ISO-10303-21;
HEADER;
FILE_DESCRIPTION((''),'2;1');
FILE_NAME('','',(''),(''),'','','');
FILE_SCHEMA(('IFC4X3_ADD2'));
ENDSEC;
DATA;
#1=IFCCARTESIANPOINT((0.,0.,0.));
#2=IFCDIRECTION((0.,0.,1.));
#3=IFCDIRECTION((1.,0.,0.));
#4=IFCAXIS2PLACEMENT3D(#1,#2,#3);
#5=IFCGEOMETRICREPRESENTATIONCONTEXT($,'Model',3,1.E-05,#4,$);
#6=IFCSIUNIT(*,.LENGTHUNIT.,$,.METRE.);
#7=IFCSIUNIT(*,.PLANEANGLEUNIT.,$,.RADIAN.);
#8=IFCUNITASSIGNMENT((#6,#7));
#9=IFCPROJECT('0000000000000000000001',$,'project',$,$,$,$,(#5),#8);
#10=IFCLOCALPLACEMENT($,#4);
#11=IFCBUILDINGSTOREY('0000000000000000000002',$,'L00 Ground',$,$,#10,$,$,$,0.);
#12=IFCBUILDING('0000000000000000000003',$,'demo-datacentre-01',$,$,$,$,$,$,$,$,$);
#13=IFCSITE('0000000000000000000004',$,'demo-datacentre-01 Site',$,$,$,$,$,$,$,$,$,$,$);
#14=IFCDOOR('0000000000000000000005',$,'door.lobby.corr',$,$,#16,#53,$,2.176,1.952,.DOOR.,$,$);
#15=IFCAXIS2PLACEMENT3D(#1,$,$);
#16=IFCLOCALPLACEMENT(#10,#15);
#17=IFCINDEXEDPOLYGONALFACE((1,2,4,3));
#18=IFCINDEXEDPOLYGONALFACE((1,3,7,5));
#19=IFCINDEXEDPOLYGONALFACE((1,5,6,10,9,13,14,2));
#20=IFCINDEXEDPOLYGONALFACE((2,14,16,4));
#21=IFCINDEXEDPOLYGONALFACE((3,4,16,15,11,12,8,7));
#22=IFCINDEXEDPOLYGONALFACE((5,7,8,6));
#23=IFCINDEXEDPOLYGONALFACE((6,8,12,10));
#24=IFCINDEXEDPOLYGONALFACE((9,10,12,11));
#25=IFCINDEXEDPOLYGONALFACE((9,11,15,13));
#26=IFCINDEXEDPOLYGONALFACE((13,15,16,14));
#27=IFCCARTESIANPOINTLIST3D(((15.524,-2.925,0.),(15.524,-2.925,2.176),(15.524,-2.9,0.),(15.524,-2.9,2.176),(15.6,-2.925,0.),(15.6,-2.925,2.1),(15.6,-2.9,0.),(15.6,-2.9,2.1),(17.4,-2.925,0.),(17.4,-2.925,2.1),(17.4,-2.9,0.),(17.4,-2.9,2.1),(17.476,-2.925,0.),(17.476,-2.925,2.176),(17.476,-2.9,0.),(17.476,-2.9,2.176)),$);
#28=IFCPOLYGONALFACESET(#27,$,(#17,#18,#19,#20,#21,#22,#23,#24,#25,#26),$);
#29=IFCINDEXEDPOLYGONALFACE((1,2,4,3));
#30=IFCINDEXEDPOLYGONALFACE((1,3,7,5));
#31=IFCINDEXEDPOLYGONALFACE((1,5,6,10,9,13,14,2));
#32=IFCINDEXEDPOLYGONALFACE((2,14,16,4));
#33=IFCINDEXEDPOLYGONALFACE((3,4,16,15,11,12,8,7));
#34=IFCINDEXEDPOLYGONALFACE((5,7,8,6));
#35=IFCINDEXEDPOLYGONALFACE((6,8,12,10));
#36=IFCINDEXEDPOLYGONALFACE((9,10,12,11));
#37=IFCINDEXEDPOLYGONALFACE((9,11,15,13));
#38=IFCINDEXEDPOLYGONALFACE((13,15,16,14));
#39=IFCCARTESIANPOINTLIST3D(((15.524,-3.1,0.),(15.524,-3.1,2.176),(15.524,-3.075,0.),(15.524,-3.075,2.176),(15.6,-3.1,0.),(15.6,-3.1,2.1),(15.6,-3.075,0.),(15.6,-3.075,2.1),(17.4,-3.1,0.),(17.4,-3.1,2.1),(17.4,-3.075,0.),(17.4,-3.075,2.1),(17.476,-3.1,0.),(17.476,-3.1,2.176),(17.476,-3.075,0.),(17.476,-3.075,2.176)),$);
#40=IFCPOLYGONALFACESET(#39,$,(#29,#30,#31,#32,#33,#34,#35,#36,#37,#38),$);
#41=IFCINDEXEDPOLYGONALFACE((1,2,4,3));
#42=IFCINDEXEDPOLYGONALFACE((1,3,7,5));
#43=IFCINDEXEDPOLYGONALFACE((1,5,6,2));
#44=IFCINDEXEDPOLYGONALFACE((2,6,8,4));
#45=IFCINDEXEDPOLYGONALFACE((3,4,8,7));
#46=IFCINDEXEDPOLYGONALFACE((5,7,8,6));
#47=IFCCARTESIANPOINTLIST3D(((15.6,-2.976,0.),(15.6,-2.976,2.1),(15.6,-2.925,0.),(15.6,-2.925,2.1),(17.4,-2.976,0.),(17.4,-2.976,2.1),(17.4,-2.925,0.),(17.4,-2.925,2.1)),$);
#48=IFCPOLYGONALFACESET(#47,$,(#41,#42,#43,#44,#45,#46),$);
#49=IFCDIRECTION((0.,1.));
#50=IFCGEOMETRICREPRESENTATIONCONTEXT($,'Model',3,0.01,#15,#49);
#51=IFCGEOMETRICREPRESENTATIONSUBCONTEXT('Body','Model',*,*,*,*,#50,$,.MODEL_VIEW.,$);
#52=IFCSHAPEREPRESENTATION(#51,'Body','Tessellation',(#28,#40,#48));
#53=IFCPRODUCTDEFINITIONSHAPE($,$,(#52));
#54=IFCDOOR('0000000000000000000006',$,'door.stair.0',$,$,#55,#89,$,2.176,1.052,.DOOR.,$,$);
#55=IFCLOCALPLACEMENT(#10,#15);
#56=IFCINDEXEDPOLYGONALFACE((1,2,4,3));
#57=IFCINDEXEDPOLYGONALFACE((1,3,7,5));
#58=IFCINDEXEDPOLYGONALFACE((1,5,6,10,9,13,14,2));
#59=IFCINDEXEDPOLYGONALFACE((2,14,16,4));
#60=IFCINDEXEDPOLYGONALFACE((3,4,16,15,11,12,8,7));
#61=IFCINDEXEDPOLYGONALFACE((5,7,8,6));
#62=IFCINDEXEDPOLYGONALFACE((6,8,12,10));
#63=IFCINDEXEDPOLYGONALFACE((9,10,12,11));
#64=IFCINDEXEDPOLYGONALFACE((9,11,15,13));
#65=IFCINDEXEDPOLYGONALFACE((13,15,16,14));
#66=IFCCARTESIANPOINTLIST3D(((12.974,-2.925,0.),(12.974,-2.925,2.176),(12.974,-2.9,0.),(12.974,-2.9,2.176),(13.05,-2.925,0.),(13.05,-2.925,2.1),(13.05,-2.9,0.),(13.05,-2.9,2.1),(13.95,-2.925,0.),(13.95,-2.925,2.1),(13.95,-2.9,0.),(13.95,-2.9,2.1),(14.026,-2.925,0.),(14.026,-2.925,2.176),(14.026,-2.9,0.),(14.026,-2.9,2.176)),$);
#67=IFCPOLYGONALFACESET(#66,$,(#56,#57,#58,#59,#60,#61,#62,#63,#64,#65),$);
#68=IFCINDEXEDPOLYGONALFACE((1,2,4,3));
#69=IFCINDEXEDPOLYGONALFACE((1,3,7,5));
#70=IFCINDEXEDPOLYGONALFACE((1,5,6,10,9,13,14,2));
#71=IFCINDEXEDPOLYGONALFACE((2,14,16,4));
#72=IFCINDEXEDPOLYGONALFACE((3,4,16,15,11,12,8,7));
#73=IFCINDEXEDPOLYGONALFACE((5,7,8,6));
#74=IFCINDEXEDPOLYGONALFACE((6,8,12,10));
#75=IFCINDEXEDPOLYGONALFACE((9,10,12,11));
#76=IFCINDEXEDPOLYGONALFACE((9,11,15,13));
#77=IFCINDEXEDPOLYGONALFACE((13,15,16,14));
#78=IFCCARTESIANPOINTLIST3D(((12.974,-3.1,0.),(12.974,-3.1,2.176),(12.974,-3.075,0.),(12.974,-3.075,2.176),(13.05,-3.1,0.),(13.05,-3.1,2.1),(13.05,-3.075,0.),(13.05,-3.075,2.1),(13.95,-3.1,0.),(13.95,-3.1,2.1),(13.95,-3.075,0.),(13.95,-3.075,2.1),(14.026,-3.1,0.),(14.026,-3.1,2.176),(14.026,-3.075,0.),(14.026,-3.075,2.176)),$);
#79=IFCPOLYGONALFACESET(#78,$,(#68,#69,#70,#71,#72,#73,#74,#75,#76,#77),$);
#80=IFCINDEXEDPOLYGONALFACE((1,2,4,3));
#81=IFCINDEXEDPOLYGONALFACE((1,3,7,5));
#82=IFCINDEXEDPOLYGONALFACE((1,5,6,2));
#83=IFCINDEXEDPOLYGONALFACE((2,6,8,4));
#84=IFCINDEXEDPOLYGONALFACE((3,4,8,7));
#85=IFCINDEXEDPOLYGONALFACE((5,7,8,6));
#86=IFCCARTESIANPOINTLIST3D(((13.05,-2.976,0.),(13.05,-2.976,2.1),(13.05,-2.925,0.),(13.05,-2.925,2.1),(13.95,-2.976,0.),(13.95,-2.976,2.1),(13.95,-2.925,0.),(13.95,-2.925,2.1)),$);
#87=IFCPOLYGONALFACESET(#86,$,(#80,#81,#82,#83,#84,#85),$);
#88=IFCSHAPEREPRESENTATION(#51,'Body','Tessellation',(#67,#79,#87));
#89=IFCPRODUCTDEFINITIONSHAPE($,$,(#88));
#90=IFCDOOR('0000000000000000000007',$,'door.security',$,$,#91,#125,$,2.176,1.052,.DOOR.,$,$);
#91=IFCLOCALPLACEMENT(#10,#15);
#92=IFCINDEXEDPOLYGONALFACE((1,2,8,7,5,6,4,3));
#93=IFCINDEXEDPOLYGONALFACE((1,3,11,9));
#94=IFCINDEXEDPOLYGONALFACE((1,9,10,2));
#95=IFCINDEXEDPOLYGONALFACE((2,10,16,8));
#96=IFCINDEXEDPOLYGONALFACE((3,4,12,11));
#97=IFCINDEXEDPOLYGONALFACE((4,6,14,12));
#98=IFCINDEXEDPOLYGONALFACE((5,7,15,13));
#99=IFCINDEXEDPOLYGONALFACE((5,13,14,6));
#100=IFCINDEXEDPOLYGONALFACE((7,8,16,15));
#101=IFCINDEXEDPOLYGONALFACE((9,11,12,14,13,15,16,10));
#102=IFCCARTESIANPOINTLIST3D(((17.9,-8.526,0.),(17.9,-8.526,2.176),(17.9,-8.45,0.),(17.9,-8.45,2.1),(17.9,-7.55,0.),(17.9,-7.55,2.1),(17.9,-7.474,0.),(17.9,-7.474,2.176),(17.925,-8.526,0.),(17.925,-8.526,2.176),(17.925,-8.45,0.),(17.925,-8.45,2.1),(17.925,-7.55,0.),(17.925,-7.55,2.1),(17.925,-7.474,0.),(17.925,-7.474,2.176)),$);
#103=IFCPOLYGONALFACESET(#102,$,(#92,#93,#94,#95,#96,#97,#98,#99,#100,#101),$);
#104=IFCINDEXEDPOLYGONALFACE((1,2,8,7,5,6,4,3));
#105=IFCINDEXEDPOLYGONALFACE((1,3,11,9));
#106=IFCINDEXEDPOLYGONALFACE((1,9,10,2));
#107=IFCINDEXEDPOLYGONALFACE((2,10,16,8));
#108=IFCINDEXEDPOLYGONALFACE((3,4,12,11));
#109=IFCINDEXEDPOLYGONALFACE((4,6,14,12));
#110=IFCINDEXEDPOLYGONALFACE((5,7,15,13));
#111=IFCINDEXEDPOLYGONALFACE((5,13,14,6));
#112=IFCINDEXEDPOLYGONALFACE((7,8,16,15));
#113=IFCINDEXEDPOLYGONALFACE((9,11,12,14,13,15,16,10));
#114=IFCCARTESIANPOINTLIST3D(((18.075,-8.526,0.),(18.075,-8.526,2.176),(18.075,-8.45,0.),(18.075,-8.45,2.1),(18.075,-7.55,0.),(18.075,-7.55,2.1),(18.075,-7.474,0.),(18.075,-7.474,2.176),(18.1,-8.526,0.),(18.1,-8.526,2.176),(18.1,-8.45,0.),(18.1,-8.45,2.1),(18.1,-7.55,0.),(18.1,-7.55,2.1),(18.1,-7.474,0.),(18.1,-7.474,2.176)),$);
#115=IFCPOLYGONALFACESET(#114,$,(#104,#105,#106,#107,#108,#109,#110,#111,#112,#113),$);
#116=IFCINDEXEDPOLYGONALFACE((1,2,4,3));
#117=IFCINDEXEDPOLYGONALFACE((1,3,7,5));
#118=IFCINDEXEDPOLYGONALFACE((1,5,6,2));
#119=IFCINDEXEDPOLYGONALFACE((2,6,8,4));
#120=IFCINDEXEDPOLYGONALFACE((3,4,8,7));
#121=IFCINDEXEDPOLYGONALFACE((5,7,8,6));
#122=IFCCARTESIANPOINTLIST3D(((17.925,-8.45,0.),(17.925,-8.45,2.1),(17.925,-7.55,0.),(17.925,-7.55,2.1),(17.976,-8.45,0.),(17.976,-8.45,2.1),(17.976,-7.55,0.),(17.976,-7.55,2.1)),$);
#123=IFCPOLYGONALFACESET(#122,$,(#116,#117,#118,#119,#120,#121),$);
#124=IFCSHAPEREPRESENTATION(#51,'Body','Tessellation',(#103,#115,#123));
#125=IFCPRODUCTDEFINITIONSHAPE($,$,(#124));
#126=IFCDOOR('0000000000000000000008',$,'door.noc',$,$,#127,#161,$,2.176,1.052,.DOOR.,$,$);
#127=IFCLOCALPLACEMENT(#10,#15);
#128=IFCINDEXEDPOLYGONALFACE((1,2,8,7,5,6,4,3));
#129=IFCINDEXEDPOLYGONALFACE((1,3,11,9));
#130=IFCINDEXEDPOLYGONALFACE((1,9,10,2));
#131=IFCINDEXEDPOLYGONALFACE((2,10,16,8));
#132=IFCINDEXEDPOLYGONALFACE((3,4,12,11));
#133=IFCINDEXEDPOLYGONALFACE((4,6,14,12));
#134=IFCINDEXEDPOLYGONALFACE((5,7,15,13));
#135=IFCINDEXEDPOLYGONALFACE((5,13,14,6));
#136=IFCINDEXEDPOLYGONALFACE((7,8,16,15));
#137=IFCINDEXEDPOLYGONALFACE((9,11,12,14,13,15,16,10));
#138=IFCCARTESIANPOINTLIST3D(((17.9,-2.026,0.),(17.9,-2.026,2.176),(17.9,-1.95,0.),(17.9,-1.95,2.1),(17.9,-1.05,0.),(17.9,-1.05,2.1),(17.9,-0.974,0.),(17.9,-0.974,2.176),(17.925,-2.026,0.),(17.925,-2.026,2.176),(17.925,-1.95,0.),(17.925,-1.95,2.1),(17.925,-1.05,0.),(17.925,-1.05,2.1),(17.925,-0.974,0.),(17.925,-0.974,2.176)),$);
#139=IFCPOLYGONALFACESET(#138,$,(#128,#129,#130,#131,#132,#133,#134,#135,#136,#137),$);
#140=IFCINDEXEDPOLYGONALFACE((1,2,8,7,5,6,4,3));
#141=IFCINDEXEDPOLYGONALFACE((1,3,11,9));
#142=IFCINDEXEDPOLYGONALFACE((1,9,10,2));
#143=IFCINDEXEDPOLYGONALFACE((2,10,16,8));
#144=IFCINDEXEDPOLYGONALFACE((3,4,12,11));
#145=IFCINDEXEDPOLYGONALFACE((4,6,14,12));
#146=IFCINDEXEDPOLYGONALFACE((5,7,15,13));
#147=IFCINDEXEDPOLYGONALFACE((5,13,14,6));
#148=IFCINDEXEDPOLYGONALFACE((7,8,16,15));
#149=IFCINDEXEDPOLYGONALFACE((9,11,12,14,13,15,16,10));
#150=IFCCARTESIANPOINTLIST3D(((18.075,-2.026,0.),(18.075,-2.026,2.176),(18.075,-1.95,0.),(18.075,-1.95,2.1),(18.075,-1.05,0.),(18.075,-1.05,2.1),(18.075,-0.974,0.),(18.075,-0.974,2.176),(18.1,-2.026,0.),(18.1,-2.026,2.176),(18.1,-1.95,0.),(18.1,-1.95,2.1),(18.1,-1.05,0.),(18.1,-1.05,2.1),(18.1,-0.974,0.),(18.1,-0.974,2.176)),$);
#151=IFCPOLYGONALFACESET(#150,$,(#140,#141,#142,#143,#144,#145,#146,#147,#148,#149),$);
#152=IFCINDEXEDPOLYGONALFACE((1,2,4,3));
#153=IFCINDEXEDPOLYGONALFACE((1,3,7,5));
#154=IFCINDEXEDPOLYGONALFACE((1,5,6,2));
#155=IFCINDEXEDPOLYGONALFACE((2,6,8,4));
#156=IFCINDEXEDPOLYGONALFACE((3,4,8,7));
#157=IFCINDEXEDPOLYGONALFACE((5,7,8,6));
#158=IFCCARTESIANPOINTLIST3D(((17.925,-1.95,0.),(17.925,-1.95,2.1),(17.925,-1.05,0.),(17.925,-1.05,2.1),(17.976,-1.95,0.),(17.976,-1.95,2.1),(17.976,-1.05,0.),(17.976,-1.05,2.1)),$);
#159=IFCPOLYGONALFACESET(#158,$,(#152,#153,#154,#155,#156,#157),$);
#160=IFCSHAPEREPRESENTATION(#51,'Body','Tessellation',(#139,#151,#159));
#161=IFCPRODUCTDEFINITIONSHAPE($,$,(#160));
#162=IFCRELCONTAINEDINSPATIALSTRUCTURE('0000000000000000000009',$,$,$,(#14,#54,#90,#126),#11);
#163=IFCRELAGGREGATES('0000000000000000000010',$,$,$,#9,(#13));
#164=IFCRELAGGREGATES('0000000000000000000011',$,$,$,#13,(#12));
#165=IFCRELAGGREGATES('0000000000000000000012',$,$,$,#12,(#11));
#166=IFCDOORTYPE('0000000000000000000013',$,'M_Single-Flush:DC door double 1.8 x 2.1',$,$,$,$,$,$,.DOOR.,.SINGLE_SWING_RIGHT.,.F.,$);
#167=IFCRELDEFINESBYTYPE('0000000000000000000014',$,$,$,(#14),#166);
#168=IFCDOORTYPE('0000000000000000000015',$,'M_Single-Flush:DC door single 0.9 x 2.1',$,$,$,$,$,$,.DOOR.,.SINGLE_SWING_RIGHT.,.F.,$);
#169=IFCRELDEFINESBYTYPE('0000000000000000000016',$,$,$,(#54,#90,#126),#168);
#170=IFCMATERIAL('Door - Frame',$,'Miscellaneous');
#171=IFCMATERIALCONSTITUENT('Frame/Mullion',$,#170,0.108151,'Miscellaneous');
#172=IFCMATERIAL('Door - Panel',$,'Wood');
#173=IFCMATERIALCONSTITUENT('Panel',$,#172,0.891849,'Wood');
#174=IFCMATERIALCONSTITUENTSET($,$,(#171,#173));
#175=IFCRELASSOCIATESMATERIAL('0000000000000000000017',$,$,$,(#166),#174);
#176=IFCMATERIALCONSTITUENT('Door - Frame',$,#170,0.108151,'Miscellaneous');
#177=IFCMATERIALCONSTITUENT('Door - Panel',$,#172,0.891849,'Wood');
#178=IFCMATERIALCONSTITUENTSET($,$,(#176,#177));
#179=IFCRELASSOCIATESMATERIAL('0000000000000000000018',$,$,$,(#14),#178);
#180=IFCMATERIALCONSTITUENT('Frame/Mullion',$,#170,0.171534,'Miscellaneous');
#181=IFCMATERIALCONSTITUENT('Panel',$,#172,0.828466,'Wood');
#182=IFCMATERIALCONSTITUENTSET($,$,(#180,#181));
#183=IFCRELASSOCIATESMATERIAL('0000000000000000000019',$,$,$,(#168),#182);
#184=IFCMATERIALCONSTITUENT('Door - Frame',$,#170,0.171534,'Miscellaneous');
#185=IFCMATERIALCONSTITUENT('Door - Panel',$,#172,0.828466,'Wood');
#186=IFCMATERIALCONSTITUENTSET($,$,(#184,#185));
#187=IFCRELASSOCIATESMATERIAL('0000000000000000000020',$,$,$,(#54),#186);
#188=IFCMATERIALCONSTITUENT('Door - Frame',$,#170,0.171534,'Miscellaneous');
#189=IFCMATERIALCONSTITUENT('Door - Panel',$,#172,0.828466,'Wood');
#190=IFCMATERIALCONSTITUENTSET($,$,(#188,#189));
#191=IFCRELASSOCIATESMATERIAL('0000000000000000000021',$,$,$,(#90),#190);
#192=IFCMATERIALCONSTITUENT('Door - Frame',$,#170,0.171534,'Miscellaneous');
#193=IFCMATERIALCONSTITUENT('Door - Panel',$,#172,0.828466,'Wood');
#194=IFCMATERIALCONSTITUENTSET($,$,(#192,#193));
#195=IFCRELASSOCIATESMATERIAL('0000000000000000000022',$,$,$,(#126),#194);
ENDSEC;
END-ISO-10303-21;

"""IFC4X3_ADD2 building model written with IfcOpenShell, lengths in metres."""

from ifc_helpers import new_model, si_unit, direction, frame, frame_2d, origin, origin_with_axes, place, context, subcontext, project, spatial, polyline, rectangle, outline, extrude, source, transform, mapped, material, constituent, constituent_set, type_object, type_shapes, element, save


model = new_model("IFC4X3_ADD2")

# Units and contexts
model_context_1 = context("Model", 3, precision=0.01, world=origin(), true_north=direction((0.0, 1.0)))
model_context_2 = context("Model", 3, precision=1e-05, world=origin_with_axes())
body_context = subcontext(model_context_1, "Body", "Model", "MODEL_VIEW")
ifc_project = project(units=[si_unit("LENGTHUNIT", "METRE"), si_unit("PLANEANGLEUNIT", "RADIAN")], contexts=[model_context_2])

# Site, building, storey
site = spatial("IfcSite", under=ifc_project, Name="demo-datacentre-01 Site")
building = spatial("IfcBuilding", under=site, Name="demo-datacentre-01")
storey_placement = place(None, origin_with_axes())
storey = spatial("IfcBuildingStorey", under=building, at=storey_placement, Name="L00 Ground", Elevation=0.0)

# Shared definitions
placement_1 = place(None, origin())
placement_2 = place(placement_1, origin())
placement_3 = place(placement_2, origin())

# Doors
ifc_material_1 = material(Name="Door - Frame", Category="Miscellaneous")
ifc_material_2 = material(Name="Door - Panel", Category="Wood")
ifc_constituent_1 = constituent(ifc_material_1, Name="Door - Frame", Category="Miscellaneous", fraction=0.108151)
ifc_constituent_2 = constituent(ifc_material_2, Name="Door - Panel", Category="Wood", fraction=0.891849)
ifc_constituent_set_1 = constituent_set(constituents=[ifc_constituent_1, ifc_constituent_2])
ifc_constituent_3 = constituent(ifc_material_1, Name="Frame/Mullion", Category="Miscellaneous", fraction=0.108151)
ifc_constituent_4 = constituent(ifc_material_2, Name="Panel", Category="Wood", fraction=0.891849)
ifc_constituent_set_2 = constituent_set(constituents=[ifc_constituent_3, ifc_constituent_4])
door_type_1 = type_object("IfcDoorType", Name="M_Single-Flush:DC door double 1.8 x 2.1", OperationType="SINGLE_SWING_RIGHT", ParameterTakesPrecedence=False, PredefinedType="DOOR", material=ifc_constituent_set_2)
shared_shape_1 = source(origin(), body_context, "Body", "SweptSolid", [
    extrude(outline(polyline([(-0.976, -1.107), (0.976, -1.107), (0.976, 1.069), (0.9, 1.069), (0.9, -1.031), (-0.9, -1.031), (-0.9, 1.069), (-0.976, 1.069), (-0.976, -1.107)])), frame((0.9, 0.15, 1.069), z_axis=(0.0, 1.0, 0.0), x_axis=(1.0, 0.0, 0.0)), (0.0, 0.0, 1.0), 0.025),
    extrude(outline(polyline([(-1.107, -0.976), (1.069, -0.976), (1.069, -0.9), (-1.031, -0.9), (-1.031, 0.9), (1.069, 0.9), (1.069, 0.976), (-1.107, 0.976), (-1.107, -0.976)])), frame((0.9, -0.025, 1.069), z_axis=(0.0, 1.0, 0.0), x_axis=(0.0, 0.0, -1.0)), (0.0, 0.0, 1.0), 0.025),
    extrude(rectangle(XDim=0.051, YDim=1.8, at=frame_2d((0.0, 0.0), x_axis=(1.0, 0.0))), frame((0.9, 0.1245, 0.0), z_axis=(0.0, 0.0, 1.0), x_axis=(0.0, 1.0, 0.0)), (0.0, 0.0, 1.0), 2.1),
])
type_shapes(door_type_1, [shared_shape_1])
door_1_placement = place(placement_3, frame((15.6, -3.075, 0.0)))
element("IfcDoor", 1, at=door_1_placement, inside=storey, type_object=door_type_1, material=ifc_constituent_set_1, Name="door.lobby.corr", OverallHeight=2.176, OverallWidth=1.952, PredefinedType="DOOR", context=body_context, shape_type="MappedRepresentation", body=[
    mapped(shared_shape_1, transform((0.0, 0.0, 0.0), scale=1.0)),
])
ifc_constituent_5 = constituent(ifc_material_1, Name="Door - Frame", Category="Miscellaneous", fraction=0.171534)
ifc_constituent_6 = constituent(ifc_material_2, Name="Door - Panel", Category="Wood", fraction=0.828466)
ifc_constituent_set_3 = constituent_set(constituents=[ifc_constituent_5, ifc_constituent_6])
ifc_constituent_7 = constituent(ifc_material_1, Name="Frame/Mullion", Category="Miscellaneous", fraction=0.171534)
ifc_constituent_8 = constituent(ifc_material_2, Name="Panel", Category="Wood", fraction=0.828466)
ifc_constituent_set_4 = constituent_set(constituents=[ifc_constituent_7, ifc_constituent_8])
door_type_2 = type_object("IfcDoorType", Name="M_Single-Flush:DC door single 0.9 x 2.1", OperationType="SINGLE_SWING_RIGHT", ParameterTakesPrecedence=False, PredefinedType="DOOR", material=ifc_constituent_set_4)
shared_shape_2 = source(origin(), body_context, "Body", "SweptSolid", [
    extrude(outline(polyline([(-0.526, -1.107), (0.526, -1.107), (0.526, 1.069), (0.45, 1.069), (0.45, -1.031), (-0.45, -1.031), (-0.45, 1.069), (-0.526, 1.069), (-0.526, -1.107)])), frame((0.45, 0.15, 1.069), z_axis=(0.0, 1.0, 0.0), x_axis=(1.0, 0.0, 0.0)), (0.0, 0.0, 1.0), 0.025),
    extrude(outline(polyline([(-1.107, -0.526), (1.069, -0.526), (1.069, -0.45), (-1.031, -0.45), (-1.031, 0.45), (1.069, 0.45), (1.069, 0.526), (-1.107, 0.526), (-1.107, -0.526)])), frame((0.45, -0.025, 1.069), z_axis=(0.0, 1.0, 0.0), x_axis=(0.0, 0.0, -1.0)), (0.0, 0.0, 1.0), 0.025),
    extrude(rectangle(XDim=0.051, YDim=0.9, at=frame_2d((0.0, 0.0), x_axis=(1.0, 0.0))), frame((0.45, 0.1245, 0.0), z_axis=(0.0, 0.0, 1.0), x_axis=(0.0, 1.0, 0.0)), (0.0, 0.0, 1.0), 2.1),
])
type_shapes(door_type_2, [shared_shape_2])
door_2_placement = place(placement_3, frame((13.05, -3.075, 0.0)))
element("IfcDoor", 2, at=door_2_placement, inside=storey, type_object=door_type_2, material=ifc_constituent_set_3, Name="door.stair.0", OverallHeight=2.176, OverallWidth=1.052, PredefinedType="DOOR", context=body_context, shape_type="MappedRepresentation", body=[
    mapped(shared_shape_2, transform((0.0, 0.0, 0.0), scale=1.0)),
])
ifc_constituent_9 = constituent(ifc_material_1, Name="Door - Frame", Category="Miscellaneous", fraction=0.171534)
ifc_constituent_10 = constituent(ifc_material_2, Name="Door - Panel", Category="Wood", fraction=0.828466)
ifc_constituent_set_5 = constituent_set(constituents=[ifc_constituent_9, ifc_constituent_10])
door_3_placement = place(placement_3, frame((18.075, -8.45, 0.0), z_axis=(0.0, 0.0, 1.0), x_axis=(0.0, 1.0, 0.0)))
element("IfcDoor", 3, at=door_3_placement, inside=storey, type_object=door_type_2, material=ifc_constituent_set_5, Name="door.security", OverallHeight=2.176, OverallWidth=1.052, PredefinedType="DOOR", context=body_context, shape_type="MappedRepresentation", body=[
    mapped(shared_shape_2, transform((0.0, 0.0, 0.0), scale=1.0)),
])
ifc_constituent_11 = constituent(ifc_material_1, Name="Door - Frame", Category="Miscellaneous", fraction=0.171534)
ifc_constituent_12 = constituent(ifc_material_2, Name="Door - Panel", Category="Wood", fraction=0.828466)
ifc_constituent_set_6 = constituent_set(constituents=[ifc_constituent_11, ifc_constituent_12])
door_4_placement = place(placement_3, frame((18.075, -1.95, 0.0), z_axis=(0.0, 0.0, 1.0), x_axis=(0.0, 1.0, 0.0)))
element("IfcDoor", 4, at=door_4_placement, inside=storey, type_object=door_type_2, material=ifc_constituent_set_6, Name="door.noc", OverallHeight=2.176, OverallWidth=1.052, PredefinedType="DOOR", context=body_context, shape_type="MappedRepresentation", body=[
    mapped(shared_shape_2, transform((0.0, 0.0, 0.0), scale=1.0)),
])

save(model, "model.ifc")
